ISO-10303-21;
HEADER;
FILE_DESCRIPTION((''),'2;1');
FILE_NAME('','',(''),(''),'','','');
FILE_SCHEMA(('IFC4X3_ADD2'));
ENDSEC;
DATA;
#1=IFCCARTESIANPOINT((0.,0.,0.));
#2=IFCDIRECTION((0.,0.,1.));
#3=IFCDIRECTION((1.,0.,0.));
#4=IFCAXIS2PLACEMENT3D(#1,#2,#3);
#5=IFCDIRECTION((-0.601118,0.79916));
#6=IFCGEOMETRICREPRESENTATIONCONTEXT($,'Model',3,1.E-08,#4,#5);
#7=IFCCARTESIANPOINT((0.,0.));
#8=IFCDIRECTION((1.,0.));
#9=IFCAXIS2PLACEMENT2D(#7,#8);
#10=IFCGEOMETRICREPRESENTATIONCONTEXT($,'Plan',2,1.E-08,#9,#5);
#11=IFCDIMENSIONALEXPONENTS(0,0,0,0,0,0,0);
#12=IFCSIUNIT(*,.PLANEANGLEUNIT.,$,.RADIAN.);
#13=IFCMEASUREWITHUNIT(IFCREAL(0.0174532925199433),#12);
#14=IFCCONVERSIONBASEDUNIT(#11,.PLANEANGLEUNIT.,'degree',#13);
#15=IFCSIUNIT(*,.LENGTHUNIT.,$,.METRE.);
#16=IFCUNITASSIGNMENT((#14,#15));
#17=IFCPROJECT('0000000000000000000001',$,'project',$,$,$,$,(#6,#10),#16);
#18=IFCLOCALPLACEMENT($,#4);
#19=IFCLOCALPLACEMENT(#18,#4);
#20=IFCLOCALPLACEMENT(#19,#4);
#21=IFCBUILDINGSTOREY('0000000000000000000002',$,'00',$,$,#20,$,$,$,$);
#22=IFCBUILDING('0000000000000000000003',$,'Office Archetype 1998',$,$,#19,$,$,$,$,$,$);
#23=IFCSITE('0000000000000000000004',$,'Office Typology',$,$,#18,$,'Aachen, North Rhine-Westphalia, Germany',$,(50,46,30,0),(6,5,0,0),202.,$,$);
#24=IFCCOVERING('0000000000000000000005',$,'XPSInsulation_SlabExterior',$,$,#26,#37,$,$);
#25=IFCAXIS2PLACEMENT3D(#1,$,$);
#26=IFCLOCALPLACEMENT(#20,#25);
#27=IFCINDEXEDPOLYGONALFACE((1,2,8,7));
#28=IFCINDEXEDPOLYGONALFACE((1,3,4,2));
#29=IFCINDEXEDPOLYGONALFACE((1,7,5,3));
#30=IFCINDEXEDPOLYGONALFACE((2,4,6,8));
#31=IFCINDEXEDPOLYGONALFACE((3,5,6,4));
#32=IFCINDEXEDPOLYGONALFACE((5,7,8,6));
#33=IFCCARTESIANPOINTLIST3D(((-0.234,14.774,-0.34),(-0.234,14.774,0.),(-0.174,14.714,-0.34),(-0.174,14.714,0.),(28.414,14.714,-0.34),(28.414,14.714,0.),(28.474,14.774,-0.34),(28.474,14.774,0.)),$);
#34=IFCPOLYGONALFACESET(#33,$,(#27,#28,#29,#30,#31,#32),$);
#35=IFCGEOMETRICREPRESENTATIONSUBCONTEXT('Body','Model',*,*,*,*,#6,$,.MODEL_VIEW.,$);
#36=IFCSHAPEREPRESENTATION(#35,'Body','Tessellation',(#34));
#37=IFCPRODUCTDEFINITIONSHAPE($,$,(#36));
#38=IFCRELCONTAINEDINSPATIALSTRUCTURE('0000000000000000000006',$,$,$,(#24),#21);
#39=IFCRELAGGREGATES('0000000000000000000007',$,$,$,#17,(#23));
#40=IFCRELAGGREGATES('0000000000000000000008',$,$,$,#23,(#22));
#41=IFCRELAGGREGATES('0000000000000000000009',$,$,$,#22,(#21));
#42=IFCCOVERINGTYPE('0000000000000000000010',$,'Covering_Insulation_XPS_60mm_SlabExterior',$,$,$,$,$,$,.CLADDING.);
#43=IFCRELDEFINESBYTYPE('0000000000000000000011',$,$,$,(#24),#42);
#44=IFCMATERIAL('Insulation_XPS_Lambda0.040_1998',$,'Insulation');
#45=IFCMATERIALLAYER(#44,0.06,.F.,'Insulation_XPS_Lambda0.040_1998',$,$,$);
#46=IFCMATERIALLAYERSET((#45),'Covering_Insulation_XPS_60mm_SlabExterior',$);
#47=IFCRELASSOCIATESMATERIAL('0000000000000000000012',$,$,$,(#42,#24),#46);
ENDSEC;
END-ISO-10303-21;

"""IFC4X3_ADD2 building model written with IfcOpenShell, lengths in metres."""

from ifc_helpers import new_model, entity, si_unit, converted_unit, direction, frame, origin_with_axes, origin_2d_with_axis, place, context, subcontext, project, spatial, line, indexed_curve, outline, extrude, material, layer, layer_set, layer_usage, type_object, element, save


model = new_model("IFC4X3_ADD2")

# Units and contexts
model_context = context("Model", 3, precision=1e-08, world=origin_with_axes(), true_north=direction((-0.601118, 0.79916)))
plan_context = context("Plan", 2, precision=1e-08, world=origin_2d_with_axis(), true_north=direction((-0.601118, 0.79916)))
body_context = subcontext(model_context, "Body", "Model", "MODEL_VIEW")
ifc_project = project(units=[converted_unit("PLANEANGLEUNIT", "degree", entity("IfcReal", 0.0174532925199433), si_unit("PLANEANGLEUNIT", "RADIAN"), dimensions=[0, 0, 0, 0, 0, 0, 0]), si_unit("LENGTHUNIT", "METRE")], contexts=[model_context, plan_context])

# Site, building, storey
site_placement = place(None, origin_with_axes())
site = spatial("IfcSite", under=ifc_project, at=site_placement, Name="Office Typology", LongName="Aachen, North Rhine-Westphalia, Germany", RefLatitude=(50, 46, 30, 0), RefLongitude=(6, 5, 0, 0), RefElevation=202.0)
building_placement = place(site_placement, origin_with_axes())
building = spatial("IfcBuilding", under=site, at=building_placement, Name="Office Archetype 1998")
storey_placement = place(building_placement, origin_with_axes())
storey = spatial("IfcBuildingStorey", under=building, at=storey_placement, Name="00")

# Covering
ifc_material_1 = material(Name="Insulation_XPS_Lambda0.040_1998", Category="Insulation")
ifc_layer_1 = layer(ifc_material_1, 0.06, ventilated=False, Name="Insulation_XPS_Lambda0.040_1998")
ifc_layer_set_1 = layer_set([ifc_layer_1], Name="Covering_Insulation_XPS_60mm_SlabExterior")
ifc_layer_usage_1 = layer_usage(ifc_layer_set_1, "AXIS2", "POSITIVE", 0.0)
covering_type = type_object("IfcCoveringType", Name="Covering_Insulation_XPS_60mm_SlabExterior", PredefinedType="CLADDING", material=ifc_layer_set_1)
covering_placement = place(storey_placement, frame((28.474, 14.774, -0.34), z_axis=(0.0, 0.0, 1.0), x_axis=(-1.0, 0.0, 0.0)))
element("IfcCovering", 1, at=covering_placement, inside=storey, type_object=covering_type, material=ifc_layer_usage_1, Name="XPSInsulation_SlabExterior", context=body_context, shape_type="SweptSolid", body=[
    extrude(outline(indexed_curve([(0.0, 0.0), (0.06, 0.06), (28.648, 0.06), (28.708, 0.0)], segments=[line(1, 2, 3, 4, 1)])), origin_with_axes(), (0.0, 0.0, 1.0), 0.34),
])

save(model, "model.ifc")
